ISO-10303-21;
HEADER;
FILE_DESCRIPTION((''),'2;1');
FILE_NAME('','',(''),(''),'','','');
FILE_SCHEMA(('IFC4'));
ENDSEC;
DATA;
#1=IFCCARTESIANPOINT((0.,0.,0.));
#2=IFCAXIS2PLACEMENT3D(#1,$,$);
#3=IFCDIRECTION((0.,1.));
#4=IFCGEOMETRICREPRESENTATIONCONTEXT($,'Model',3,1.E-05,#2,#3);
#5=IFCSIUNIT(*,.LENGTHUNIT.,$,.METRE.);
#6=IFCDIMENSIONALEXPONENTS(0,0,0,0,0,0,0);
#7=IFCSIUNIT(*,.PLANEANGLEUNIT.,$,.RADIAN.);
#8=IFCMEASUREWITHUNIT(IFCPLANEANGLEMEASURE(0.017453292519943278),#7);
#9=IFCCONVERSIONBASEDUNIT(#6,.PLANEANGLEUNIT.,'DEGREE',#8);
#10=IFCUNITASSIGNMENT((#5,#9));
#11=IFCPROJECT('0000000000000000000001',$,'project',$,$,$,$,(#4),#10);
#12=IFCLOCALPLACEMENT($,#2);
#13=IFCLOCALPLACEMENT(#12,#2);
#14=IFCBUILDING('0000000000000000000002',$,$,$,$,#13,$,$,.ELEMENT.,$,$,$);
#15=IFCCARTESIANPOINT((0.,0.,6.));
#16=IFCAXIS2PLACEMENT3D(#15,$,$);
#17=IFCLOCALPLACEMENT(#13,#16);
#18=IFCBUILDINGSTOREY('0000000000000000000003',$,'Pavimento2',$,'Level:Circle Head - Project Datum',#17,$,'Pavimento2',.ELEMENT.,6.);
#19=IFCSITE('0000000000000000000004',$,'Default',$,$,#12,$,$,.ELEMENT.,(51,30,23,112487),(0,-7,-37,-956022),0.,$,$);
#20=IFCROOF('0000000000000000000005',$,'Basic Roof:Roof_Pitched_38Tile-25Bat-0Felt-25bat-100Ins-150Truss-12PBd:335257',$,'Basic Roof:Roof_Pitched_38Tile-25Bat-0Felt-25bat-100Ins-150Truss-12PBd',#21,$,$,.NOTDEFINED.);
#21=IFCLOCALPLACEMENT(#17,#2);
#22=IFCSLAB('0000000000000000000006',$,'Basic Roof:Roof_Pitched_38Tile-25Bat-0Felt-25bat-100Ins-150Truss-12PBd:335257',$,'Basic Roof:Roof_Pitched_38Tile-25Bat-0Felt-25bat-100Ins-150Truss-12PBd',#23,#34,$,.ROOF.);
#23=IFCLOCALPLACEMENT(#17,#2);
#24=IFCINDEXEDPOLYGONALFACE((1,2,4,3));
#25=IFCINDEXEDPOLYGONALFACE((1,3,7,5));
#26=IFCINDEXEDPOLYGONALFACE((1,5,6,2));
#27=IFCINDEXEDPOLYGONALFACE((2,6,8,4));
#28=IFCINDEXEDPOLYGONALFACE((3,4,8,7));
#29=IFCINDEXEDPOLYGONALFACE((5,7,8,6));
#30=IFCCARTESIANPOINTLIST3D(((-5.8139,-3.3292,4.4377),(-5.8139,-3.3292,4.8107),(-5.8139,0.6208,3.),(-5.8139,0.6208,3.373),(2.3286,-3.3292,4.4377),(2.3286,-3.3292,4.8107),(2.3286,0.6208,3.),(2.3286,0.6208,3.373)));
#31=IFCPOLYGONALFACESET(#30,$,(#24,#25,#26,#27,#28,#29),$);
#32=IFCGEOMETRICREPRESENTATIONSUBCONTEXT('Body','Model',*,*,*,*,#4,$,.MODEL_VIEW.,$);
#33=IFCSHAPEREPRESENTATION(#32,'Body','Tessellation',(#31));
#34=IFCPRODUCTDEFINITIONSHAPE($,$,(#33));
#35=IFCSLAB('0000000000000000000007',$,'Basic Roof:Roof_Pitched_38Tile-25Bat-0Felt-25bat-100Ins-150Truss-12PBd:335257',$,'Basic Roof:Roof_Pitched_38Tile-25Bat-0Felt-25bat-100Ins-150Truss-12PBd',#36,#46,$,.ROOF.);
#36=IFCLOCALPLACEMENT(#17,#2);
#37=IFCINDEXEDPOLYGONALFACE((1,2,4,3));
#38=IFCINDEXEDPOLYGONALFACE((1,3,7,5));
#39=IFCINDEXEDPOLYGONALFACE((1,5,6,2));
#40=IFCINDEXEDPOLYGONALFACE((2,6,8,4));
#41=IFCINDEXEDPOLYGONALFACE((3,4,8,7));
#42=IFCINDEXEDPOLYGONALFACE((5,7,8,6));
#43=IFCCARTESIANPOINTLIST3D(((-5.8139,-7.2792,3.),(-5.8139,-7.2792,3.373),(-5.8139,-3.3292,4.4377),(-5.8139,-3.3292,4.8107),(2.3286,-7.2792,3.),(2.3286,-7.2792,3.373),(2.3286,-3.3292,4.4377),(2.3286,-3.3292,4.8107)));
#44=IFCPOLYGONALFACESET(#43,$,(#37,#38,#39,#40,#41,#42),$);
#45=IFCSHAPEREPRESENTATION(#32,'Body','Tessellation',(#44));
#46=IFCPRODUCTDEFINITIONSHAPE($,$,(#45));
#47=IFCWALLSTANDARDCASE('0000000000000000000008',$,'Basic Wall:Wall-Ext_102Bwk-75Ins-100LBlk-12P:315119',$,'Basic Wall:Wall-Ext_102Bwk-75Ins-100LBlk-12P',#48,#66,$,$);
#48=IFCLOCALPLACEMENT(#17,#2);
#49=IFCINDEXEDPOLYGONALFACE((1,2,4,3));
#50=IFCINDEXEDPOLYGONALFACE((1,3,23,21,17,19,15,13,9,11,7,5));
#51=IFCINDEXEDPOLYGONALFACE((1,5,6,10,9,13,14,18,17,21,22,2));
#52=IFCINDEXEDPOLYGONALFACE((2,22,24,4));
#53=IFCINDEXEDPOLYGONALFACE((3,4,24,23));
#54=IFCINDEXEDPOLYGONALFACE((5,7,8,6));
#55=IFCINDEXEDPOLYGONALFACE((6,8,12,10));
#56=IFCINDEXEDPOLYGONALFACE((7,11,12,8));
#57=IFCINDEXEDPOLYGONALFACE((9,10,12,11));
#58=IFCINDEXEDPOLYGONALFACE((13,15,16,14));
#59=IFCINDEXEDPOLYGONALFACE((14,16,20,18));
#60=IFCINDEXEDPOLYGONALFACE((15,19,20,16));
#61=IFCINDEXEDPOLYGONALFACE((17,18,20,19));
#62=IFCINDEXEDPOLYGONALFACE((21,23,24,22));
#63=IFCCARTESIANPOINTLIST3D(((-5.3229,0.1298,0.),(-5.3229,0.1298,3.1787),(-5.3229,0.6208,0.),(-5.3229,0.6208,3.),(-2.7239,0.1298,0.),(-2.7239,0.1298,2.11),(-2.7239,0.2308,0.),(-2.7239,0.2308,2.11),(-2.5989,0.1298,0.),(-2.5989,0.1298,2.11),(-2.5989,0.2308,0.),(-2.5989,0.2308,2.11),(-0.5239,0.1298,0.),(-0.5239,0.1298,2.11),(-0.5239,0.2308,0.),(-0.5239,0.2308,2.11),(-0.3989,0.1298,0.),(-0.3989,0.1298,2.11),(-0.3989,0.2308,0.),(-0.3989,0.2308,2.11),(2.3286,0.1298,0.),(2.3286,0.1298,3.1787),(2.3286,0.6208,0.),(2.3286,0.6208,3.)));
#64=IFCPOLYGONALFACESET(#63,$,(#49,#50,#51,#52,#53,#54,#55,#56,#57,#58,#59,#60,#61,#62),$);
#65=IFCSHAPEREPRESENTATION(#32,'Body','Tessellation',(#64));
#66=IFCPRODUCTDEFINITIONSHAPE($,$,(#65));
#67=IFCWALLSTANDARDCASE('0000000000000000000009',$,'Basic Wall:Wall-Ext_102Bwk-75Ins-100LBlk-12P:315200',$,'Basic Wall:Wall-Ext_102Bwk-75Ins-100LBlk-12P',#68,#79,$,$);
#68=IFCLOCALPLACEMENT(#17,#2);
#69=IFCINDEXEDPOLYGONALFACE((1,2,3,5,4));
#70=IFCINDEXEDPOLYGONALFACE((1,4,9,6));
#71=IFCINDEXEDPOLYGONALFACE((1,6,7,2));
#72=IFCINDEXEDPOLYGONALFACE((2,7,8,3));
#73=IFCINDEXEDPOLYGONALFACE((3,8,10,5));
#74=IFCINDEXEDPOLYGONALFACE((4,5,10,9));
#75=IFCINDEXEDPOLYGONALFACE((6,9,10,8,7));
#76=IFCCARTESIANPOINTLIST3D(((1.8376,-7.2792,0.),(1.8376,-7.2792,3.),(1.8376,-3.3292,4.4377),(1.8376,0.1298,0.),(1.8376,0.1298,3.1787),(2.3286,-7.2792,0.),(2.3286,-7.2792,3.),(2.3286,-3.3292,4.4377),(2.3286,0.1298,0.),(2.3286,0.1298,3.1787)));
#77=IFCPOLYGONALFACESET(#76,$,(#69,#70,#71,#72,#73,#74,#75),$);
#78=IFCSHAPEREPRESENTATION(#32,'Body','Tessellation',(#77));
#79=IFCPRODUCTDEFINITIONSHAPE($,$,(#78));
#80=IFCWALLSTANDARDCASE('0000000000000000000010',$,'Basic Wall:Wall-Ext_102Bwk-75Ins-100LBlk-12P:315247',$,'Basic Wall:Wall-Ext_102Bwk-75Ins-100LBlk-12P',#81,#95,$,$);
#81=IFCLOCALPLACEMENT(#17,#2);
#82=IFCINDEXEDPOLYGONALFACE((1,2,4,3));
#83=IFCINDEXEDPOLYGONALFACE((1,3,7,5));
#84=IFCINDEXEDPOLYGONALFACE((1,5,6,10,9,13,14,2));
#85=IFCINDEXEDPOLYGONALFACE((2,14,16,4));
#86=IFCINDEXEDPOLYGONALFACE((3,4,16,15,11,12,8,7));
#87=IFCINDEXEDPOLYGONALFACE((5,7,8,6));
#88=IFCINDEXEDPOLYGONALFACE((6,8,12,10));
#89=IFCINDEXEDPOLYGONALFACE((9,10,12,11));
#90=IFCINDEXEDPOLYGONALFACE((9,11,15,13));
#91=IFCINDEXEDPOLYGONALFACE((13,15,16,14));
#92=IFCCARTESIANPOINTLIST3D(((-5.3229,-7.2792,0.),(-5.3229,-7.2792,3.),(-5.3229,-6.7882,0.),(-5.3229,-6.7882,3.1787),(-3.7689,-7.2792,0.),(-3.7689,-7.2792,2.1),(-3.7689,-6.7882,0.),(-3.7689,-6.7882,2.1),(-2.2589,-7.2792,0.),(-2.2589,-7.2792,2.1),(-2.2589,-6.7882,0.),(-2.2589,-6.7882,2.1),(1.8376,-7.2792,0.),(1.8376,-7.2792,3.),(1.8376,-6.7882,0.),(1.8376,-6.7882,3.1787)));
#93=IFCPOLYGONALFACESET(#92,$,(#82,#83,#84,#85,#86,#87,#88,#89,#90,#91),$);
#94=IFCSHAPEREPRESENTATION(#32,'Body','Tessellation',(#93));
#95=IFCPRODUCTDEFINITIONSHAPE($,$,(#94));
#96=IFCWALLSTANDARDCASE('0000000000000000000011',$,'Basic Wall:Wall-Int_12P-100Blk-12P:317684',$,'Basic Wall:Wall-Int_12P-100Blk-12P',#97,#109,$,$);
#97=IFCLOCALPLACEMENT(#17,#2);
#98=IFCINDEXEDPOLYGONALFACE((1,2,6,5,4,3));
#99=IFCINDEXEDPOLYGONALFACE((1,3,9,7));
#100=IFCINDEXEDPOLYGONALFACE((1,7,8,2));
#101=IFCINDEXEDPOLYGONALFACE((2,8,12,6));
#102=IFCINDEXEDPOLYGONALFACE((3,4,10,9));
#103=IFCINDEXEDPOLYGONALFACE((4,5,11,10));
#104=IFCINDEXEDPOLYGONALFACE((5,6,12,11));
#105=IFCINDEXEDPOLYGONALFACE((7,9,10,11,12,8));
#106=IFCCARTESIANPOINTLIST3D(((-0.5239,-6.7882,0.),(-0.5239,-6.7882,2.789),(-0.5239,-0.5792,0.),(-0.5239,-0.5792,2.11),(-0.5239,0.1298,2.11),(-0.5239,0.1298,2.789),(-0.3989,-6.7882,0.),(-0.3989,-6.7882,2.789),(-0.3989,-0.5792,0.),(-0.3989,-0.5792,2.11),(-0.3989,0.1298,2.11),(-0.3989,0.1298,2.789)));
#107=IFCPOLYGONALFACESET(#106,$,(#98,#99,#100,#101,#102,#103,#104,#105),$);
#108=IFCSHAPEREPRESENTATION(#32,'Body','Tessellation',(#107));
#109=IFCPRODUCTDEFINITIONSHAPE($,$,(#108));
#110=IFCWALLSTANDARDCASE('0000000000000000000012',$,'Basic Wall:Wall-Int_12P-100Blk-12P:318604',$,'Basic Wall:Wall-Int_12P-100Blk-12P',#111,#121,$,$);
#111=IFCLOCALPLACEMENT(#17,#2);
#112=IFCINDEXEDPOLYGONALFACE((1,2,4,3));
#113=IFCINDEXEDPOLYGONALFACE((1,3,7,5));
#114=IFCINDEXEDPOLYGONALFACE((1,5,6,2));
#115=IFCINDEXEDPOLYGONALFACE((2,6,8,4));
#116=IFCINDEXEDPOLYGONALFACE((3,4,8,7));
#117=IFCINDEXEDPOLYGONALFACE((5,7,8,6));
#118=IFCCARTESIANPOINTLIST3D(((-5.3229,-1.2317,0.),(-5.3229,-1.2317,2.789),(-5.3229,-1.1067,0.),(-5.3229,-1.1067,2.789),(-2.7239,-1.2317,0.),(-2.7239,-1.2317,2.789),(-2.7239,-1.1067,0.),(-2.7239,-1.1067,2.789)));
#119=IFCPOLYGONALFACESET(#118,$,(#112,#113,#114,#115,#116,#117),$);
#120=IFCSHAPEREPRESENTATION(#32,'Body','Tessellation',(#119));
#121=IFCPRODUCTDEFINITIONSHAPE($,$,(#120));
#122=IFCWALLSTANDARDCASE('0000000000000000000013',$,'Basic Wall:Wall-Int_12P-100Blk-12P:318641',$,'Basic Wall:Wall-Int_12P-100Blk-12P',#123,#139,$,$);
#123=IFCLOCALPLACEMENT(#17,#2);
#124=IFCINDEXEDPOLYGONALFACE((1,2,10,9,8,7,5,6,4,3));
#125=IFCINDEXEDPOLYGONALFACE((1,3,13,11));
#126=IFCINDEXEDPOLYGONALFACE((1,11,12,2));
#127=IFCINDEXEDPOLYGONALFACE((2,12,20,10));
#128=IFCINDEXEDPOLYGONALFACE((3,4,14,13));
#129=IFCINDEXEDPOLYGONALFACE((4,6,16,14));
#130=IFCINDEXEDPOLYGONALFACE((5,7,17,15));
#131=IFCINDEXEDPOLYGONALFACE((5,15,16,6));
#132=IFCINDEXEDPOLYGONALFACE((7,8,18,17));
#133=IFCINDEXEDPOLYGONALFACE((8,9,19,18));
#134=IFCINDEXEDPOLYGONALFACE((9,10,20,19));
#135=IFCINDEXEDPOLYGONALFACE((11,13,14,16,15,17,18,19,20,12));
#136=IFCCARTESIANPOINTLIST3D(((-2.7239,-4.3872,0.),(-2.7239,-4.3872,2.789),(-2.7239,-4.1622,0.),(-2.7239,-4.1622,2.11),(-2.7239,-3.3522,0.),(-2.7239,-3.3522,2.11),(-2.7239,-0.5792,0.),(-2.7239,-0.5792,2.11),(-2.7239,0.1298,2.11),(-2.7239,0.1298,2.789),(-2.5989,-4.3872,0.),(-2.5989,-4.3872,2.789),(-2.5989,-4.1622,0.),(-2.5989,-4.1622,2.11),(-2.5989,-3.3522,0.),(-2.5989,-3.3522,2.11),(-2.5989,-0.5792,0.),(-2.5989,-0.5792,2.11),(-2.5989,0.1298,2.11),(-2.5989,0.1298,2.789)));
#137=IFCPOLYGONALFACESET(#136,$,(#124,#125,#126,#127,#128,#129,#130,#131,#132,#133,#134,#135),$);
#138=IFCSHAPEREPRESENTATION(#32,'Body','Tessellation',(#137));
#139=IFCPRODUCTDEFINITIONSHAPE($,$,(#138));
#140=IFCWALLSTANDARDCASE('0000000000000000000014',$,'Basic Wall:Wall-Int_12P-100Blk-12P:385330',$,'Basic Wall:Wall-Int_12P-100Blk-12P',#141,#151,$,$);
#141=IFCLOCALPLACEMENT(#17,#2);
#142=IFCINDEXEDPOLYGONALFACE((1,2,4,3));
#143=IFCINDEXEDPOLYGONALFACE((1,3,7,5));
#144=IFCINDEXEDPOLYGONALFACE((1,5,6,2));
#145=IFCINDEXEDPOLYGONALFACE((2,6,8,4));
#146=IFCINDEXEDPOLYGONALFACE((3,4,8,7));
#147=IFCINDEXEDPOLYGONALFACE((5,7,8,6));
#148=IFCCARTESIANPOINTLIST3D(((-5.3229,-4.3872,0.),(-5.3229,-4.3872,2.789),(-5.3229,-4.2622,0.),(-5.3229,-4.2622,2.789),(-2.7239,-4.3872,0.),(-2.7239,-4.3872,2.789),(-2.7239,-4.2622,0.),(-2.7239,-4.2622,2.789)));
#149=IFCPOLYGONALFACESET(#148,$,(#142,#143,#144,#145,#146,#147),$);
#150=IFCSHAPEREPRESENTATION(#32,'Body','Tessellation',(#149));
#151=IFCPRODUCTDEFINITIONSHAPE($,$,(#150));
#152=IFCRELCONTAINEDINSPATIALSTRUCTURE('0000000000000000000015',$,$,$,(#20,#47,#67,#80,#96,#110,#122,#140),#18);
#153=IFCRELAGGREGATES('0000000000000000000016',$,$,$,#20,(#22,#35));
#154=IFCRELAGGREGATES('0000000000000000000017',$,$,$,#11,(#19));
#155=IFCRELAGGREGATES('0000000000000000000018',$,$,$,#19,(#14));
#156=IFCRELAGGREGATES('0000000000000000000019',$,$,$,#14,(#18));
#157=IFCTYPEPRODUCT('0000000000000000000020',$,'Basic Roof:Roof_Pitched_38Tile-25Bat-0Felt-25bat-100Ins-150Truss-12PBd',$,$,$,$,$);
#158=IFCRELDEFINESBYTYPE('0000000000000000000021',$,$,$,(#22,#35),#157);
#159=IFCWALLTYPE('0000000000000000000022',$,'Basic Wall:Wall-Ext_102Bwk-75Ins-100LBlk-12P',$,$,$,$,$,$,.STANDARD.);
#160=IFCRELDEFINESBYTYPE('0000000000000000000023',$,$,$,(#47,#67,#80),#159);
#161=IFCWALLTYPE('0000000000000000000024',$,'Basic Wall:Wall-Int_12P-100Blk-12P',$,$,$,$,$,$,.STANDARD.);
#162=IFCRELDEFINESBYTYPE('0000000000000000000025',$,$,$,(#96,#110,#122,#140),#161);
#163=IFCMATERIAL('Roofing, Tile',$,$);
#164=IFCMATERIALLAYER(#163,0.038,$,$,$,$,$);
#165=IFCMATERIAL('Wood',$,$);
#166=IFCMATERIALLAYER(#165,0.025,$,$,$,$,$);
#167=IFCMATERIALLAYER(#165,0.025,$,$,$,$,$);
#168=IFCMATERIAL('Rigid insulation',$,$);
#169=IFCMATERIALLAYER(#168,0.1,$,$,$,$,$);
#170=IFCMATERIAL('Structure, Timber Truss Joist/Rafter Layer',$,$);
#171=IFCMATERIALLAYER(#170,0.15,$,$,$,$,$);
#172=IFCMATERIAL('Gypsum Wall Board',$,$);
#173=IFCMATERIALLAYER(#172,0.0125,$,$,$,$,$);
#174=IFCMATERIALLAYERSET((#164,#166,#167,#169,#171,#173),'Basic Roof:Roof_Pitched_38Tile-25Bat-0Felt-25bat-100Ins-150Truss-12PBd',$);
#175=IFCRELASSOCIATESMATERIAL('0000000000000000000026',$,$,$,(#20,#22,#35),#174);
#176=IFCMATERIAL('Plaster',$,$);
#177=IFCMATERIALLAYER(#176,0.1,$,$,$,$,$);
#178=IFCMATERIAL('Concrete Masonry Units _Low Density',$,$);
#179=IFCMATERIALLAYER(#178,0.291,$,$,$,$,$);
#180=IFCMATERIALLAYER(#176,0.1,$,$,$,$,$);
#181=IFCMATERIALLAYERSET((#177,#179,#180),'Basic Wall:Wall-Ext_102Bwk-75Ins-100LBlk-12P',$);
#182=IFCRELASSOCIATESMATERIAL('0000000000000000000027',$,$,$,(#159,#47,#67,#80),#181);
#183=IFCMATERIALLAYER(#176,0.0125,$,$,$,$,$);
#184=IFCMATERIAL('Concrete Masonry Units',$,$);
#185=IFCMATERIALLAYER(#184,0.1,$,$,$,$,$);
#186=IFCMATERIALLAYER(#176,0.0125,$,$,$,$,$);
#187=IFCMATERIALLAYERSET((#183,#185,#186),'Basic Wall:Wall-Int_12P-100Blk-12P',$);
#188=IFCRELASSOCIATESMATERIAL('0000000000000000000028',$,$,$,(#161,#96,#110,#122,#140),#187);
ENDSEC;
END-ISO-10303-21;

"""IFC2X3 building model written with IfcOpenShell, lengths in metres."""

from ifc_helpers import new_model, entity, si_unit, converted_unit, direction, frame, frame_2d, origin, origin_with_axes, place, context, subcontext, project, spatial, polyline, rectangle, extrude, clip, bounded_halfspace, material, layer, layer_set, layer_usage, type_object, element, aggregate, save


model = new_model("IFC2X3")

# Units and contexts
model_context = context("Model", 3, precision=1e-05, world=origin(), true_north=direction((0.0, 1.0)))
body_context = subcontext(model_context, "Body", "Model", "MODEL_VIEW")
ifc_project = project(units=[si_unit("LENGTHUNIT", "METRE"), converted_unit("PLANEANGLEUNIT", "DEGREE", entity("IfcPlaneAngleMeasure", 0.017453292519943278), si_unit("PLANEANGLEUNIT", "RADIAN"), dimensions=[0, 0, 0, 0, 0, 0, 0])], contexts=[model_context])

# Site, building, storey
site_placement = place(None, origin())
site = spatial("IfcSite", under=ifc_project, at=site_placement, Name="Default", CompositionType="ELEMENT", RefLatitude=(51, 30, 23, 112487), RefLongitude=(0, -7, -37, -956022), RefElevation=0.0)
building_placement = place(site_placement, origin())
building = spatial("IfcBuilding", under=site, at=building_placement, CompositionType="ELEMENT")
storey_placement = place(building_placement, frame((0.0, 0.0, 6.0)))
storey = spatial("IfcBuildingStorey", under=building, at=storey_placement, Name="Pavimento2", ObjectType="Level:Circle Head - Project Datum", LongName="Pavimento2", CompositionType="ELEMENT", Elevation=6.0)

# Roof, slabs
ifc_material_1 = material(Name="Roofing, Tile")
ifc_layer_1 = layer(ifc_material_1, 0.038)
ifc_material_2 = material(Name="Wood")
ifc_layer_2 = layer(ifc_material_2, 0.025)
ifc_layer_3 = layer(ifc_material_2, 0.025)
ifc_material_3 = material(Name="Rigid insulation")
ifc_layer_4 = layer(ifc_material_3, 0.1)
ifc_material_4 = material(Name="Structure, Timber Truss Joist/Rafter Layer")
ifc_layer_5 = layer(ifc_material_4, 0.15)
ifc_material_5 = material(Name="Gypsum Wall Board")
ifc_layer_6 = layer(ifc_material_5, 0.0125)
ifc_layer_set_1 = layer_set([ifc_layer_1, ifc_layer_2, ifc_layer_3, ifc_layer_4, ifc_layer_5, ifc_layer_6], Name="Basic Roof:Roof_Pitched_38Tile-25Bat-0Felt-25bat-100Ins-150Truss-12PBd")
roof_placement = place(storey_placement, frame((-5.8139, -7.2792, 3.0), z_axis=(0.0, 0.0, 1.0), x_axis=(1.0, 0.0, 0.0)))
roof = element("IfcRoof", 1, at=roof_placement, inside=storey, material=ifc_layer_set_1, Name="Basic Roof:Roof_Pitched_38Tile-25Bat-0Felt-25bat-100Ins-150Truss-12PBd:335257", ObjectType="Basic Roof:Roof_Pitched_38Tile-25Bat-0Felt-25bat-100Ins-150Truss-12PBd", ShapeType="NOTDEFINED")
type_product = type_object("IfcTypeProduct", Name="Basic Roof:Roof_Pitched_38Tile-25Bat-0Felt-25bat-100Ins-150Truss-12PBd")
slab_1_placement = place(roof_placement, origin_with_axes())
slab_1 = element("IfcSlab", 2, at=slab_1_placement, type_object=type_product, material=ifc_layer_set_1, Name="Basic Roof:Roof_Pitched_38Tile-25Bat-0Felt-25bat-100Ins-150Truss-12PBd:335257", ObjectType="Basic Roof:Roof_Pitched_38Tile-25Bat-0Felt-25bat-100Ins-150Truss-12PBd", PredefinedType="ROOF", context=body_context, shape_type="SweptSolid", body=[
    extrude(rectangle(XDim=8.1425, YDim=4.2035, at=frame_2d((0.0, 0.0), x_axis=(1.0, 0.0))), frame((4.0713, 5.925, 0.7188), z_axis=(0.0, 0.34202, 0.939693), x_axis=(1.0, 0.0, 0.0)), (0.0, -0.34202, 0.939693), 0.373),
])
slab_2_placement = place(roof_placement, origin_with_axes())
slab_2 = element("IfcSlab", 3, at=slab_2_placement, type_object=type_product, material=ifc_layer_set_1, Name="Basic Roof:Roof_Pitched_38Tile-25Bat-0Felt-25bat-100Ins-150Truss-12PBd:335257", ObjectType="Basic Roof:Roof_Pitched_38Tile-25Bat-0Felt-25bat-100Ins-150Truss-12PBd", PredefinedType="ROOF", context=body_context, shape_type="SweptSolid", body=[
    extrude(rectangle(XDim=4.2035, YDim=8.1425, at=frame_2d((0.0, 0.0), x_axis=(0.0, 1.0))), frame((4.0713, 1.975, 0.7188), z_axis=(0.0, -0.34202, 0.939693), x_axis=(1.0, 0.0, 0.0)), (0.0, 0.34202, 0.939693), 0.373),
])
aggregate(roof, [slab_1, slab_2])

# Wall, openings
ifc_material_6 = material(Name="Plaster")
ifc_layer_7 = layer(ifc_material_6, 0.1)
ifc_material_7 = material(Name="Concrete Masonry Units _Low Density")
ifc_layer_8 = layer(ifc_material_7, 0.291)
ifc_layer_9 = layer(ifc_material_6, 0.1)
ifc_layer_set_2 = layer_set([ifc_layer_7, ifc_layer_8, ifc_layer_9], Name="Basic Wall:Wall-Ext_102Bwk-75Ins-100LBlk-12P")
ifc_layer_usage_1 = layer_usage(ifc_layer_set_2, "AXIS2", "NEGATIVE", 0.2455)
wall_type_1 = type_object("IfcWallType", Name="Basic Wall:Wall-Ext_102Bwk-75Ins-100LBlk-12P", PredefinedType="STANDARD", material=ifc_layer_set_2)
wall_1_placement = place(storey_placement, frame((-5.3229, 0.3753, 0.0)))
wall_1 = element("IfcWallStandardCase", 4, at=wall_1_placement, inside=storey, type_object=wall_type_1, material=ifc_layer_usage_1, Name="Basic Wall:Wall-Ext_102Bwk-75Ins-100LBlk-12P:315119", ObjectType="Basic Wall:Wall-Ext_102Bwk-75Ins-100LBlk-12P", context=body_context, shape_type="Clipping", body=[
    clip(extrude(rectangle(XDim=7.6515, YDim=0.491, at=frame_2d((3.8258, 0.0), x_axis=(-1.0, 0.0))), origin(), (0.0, 0.0, 1.0), 3.1787), bounded_halfspace(frame((0.0, -0.2455, 3.1787), z_axis=(0.0, 0.34202, 0.939693), x_axis=(-1.0, 0.0, 0.0)), False, frame((0.0, -0.2455, 3.1787)), polyline([(0.0, 0.0), (7.1605, 0.0), (7.6515, 0.0), (7.6515, 0.491), (0.0, 0.491), (0.0, 0.0)]))),
])
opening_1_placement = place(wall_1_placement, origin())
element("IfcOpeningElement", 5, at=opening_1_placement, cuts=wall_1, ObjectType="Opening", context=body_context, shape_type="SweptSolid", body=[
    extrude(rectangle(XDim=2.11, YDim=0.125, at=frame_2d((0.0, 0.0), x_axis=(0.0, 1.0))), frame((2.6615, -0.9545, 1.055), z_axis=(0.0, 1.0, 0.0), x_axis=(-1.0, 0.0, 0.0)), (0.0, 0.0, 1.0), 0.81),
])
opening_2_placement = place(wall_1_placement, origin())
element("IfcOpeningElement", 6, at=opening_2_placement, cuts=wall_1, ObjectType="Opening", context=body_context, shape_type="SweptSolid", body=[
    extrude(rectangle(XDim=2.11, YDim=0.125, at=frame_2d((0.0, 0.0), x_axis=(0.0, 1.0))), frame((4.8615, -0.9545, 1.055), z_axis=(0.0, 1.0, 0.0), x_axis=(-1.0, 0.0, 0.0)), (0.0, 0.0, 1.0), 0.81),
])

# Wall
wall_2_placement = place(storey_placement, frame((2.0831, 0.1298, 0.0), z_axis=(0.0, 0.0, 1.0), x_axis=(0.0, -1.0, 0.0)))
element("IfcWallStandardCase", 7, at=wall_2_placement, inside=storey, type_object=wall_type_1, material=ifc_layer_usage_1, Name="Basic Wall:Wall-Ext_102Bwk-75Ins-100LBlk-12P:315200", ObjectType="Basic Wall:Wall-Ext_102Bwk-75Ins-100LBlk-12P", context=body_context, shape_type="Clipping", body=[
    clip(clip(extrude(rectangle(XDim=7.409, YDim=0.491, at=frame_2d((3.7045, 0.0), x_axis=(-1.0, 0.0))), origin(), (0.0, 0.0, 1.0), 4.4377), bounded_halfspace(frame((0.0, -0.2455, 3.1787), z_axis=(-0.34202, 0.0, 0.939693), x_axis=(0.0, -1.0, 0.0)), False, frame((0.0, -0.2455, 3.1787)), polyline([(0.0, 0.0), (3.459, 0.0), (3.459, 0.491), (0.0, 0.491), (0.0, 0.0)]))), bounded_halfspace(frame((3.459, -0.2455, 4.4377), z_axis=(0.34202, 0.0, 0.939693), x_axis=(0.0, 1.0, 0.0)), False, frame((3.459, -0.2455, 4.4377)), polyline([(0.0, 0.0), (3.459, 0.0), (3.95, 0.0), (3.95, 0.491), (0.0, 0.491), (0.0, 0.0)]))),
])

# Walls, openings
wall_3_placement = place(storey_placement, frame((1.8376, -7.0337, 0.0), z_axis=(0.0, 0.0, 1.0), x_axis=(-1.0, 0.0, 0.0)))
wall_3 = element("IfcWallStandardCase", 8, at=wall_3_placement, inside=storey, type_object=wall_type_1, material=ifc_layer_usage_1, Name="Basic Wall:Wall-Ext_102Bwk-75Ins-100LBlk-12P:315247", ObjectType="Basic Wall:Wall-Ext_102Bwk-75Ins-100LBlk-12P", context=body_context, shape_type="Clipping", body=[
    clip(extrude(rectangle(XDim=7.1605, YDim=0.491, at=frame_2d((3.5803, 0.0), x_axis=(1.0, 0.0))), origin(), (0.0, 0.0, 1.0), 3.1787), bounded_halfspace(frame((0.0, -0.2455, 3.1787), z_axis=(0.0, 0.34202, 0.939693), x_axis=(-1.0, 0.0, 0.0)), False, frame((0.0, -0.2455, 3.1787)), polyline([(0.0, 0.0), (7.1605, 0.0), (7.1605, 0.491), (0.0, 0.491), (0.0, 0.0)]))),
])
opening_3_placement = place(wall_3_placement, frame((1.8376, -7.0337, 0.0), z_axis=(0.0, 0.0, 1.0), x_axis=(-1.0, 0.0, 0.0)))
element("IfcOpeningElement", 9, at=opening_3_placement, cuts=wall_3, ObjectType="Opening", context=body_context, shape_type="SweptSolid", body=[
    extrude(rectangle(XDim=2.1, YDim=1.51, at=frame_2d((0.0, 0.0), x_axis=(0.0, 1.0))), frame((-3.0139, -6.4882, 1.05), z_axis=(0.0, -1.0, 0.0), x_axis=(-1.0, 0.0, 0.0)), (0.0, 0.0, 1.0), 1.091),
])
ifc_layer_10 = layer(ifc_material_6, 0.0125)
ifc_material_8 = material(Name="Concrete Masonry Units")
ifc_layer_11 = layer(ifc_material_8, 0.1)
ifc_layer_12 = layer(ifc_material_6, 0.0125)
ifc_layer_set_3 = layer_set([ifc_layer_10, ifc_layer_11, ifc_layer_12], Name="Basic Wall:Wall-Int_12P-100Blk-12P")
ifc_layer_usage_2 = layer_usage(ifc_layer_set_3, "AXIS2", "NEGATIVE", 0.0625)
wall_type_2 = type_object("IfcWallType", Name="Basic Wall:Wall-Int_12P-100Blk-12P", PredefinedType="STANDARD", material=ifc_layer_set_3)
wall_4_placement = place(storey_placement, frame((-0.4614, 0.1298, 0.0), z_axis=(0.0, 0.0, 1.0), x_axis=(0.0, -1.0, 0.0)))
wall_4 = element("IfcWallStandardCase", 10, at=wall_4_placement, inside=storey, type_object=wall_type_2, material=ifc_layer_usage_2, Name="Basic Wall:Wall-Int_12P-100Blk-12P:317684", ObjectType="Basic Wall:Wall-Int_12P-100Blk-12P", context=body_context, shape_type="SweptSolid", body=[
    extrude(rectangle(XDim=6.918, YDim=0.125, at=frame_2d((3.459, 0.0), x_axis=(-1.0, 0.0))), origin(), (0.0, 0.0, 1.0), 2.789),
])
opening_4_placement = place(wall_4_placement, frame((0.709, 0.0625, 0.0)))
element("IfcOpeningElement", 11, at=opening_4_placement, cuts=wall_4, ObjectType="Opening", context=body_context, shape_type="SweptSolid", body=[
    extrude(rectangle(XDim=2.11, YDim=0.81, at=frame_2d((1.055, 0.405), x_axis=(1.0, 0.0))), frame((0.0, 0.0, 0.0), z_axis=(0.0, -1.0, 0.0), x_axis=(0.0, 0.0, 1.0)), (0.0, 0.0, 1.0), 0.125),
])

# Wall
wall_5_placement = place(storey_placement, frame((-2.7239, -1.1692, 0.0), z_axis=(0.0, 0.0, 1.0), x_axis=(-1.0, 0.0, 0.0)))
element("IfcWallStandardCase", 12, at=wall_5_placement, inside=storey, type_object=wall_type_2, material=ifc_layer_usage_2, Name="Basic Wall:Wall-Int_12P-100Blk-12P:318604", ObjectType="Basic Wall:Wall-Int_12P-100Blk-12P", context=body_context, shape_type="SweptSolid", body=[
    extrude(rectangle(XDim=2.599, YDim=0.125, at=frame_2d((1.2995, 0.0), x_axis=(-1.0, 0.0))), origin(), (0.0, 0.0, 1.0), 2.789),
])

# Wall, openings
wall_6_placement = place(storey_placement, frame((-2.6614, 0.1298, 0.0), z_axis=(0.0, 0.0, 1.0), x_axis=(0.0, -1.0, 0.0)))
wall_6 = element("IfcWallStandardCase", 13, at=wall_6_placement, inside=storey, type_object=wall_type_2, material=ifc_layer_usage_2, Name="Basic Wall:Wall-Int_12P-100Blk-12P:318641", ObjectType="Basic Wall:Wall-Int_12P-100Blk-12P", context=body_context, shape_type="SweptSolid", body=[
    extrude(rectangle(XDim=4.517, YDim=0.125, at=frame_2d((2.2585, 0.0), x_axis=(-1.0, 0.0))), origin(), (0.0, 0.0, 1.0), 2.789),
])
opening_5_placement = place(wall_6_placement, frame((0.709, 0.0625, 0.0)))
element("IfcOpeningElement", 14, at=opening_5_placement, cuts=wall_6, ObjectType="Opening", context=body_context, shape_type="SweptSolid", body=[
    extrude(rectangle(XDim=2.11, YDim=0.81, at=frame_2d((1.055, 0.405), x_axis=(1.0, 0.0))), frame((0.0, 0.0, 0.0), z_axis=(0.0, -1.0, 0.0), x_axis=(0.0, 0.0, 1.0)), (0.0, 0.0, 1.0), 0.125),
])
opening_6_placement = place(wall_6_placement, frame((4.292, 0.0625, 0.0)))
element("IfcOpeningElement", 15, at=opening_6_placement, cuts=wall_6, ObjectType="Opening", context=body_context, shape_type="SweptSolid", body=[
    extrude(rectangle(XDim=2.11, YDim=0.81, at=frame_2d((1.055, 0.405), x_axis=(1.0, 0.0))), frame((0.0, 0.0, 0.0), z_axis=(0.0, -1.0, 0.0), x_axis=(0.0, 0.0, 1.0)), (0.0, 0.0, 1.0), 0.125),
])

# Wall
wall_7_placement = place(storey_placement, frame((-2.7239, -4.3247, 0.0), z_axis=(0.0, 0.0, 1.0), x_axis=(-1.0, 0.0, 0.0)))
element("IfcWallStandardCase", 16, at=wall_7_placement, inside=storey, type_object=wall_type_2, material=ifc_layer_usage_2, Name="Basic Wall:Wall-Int_12P-100Blk-12P:385330", ObjectType="Basic Wall:Wall-Int_12P-100Blk-12P", context=body_context, shape_type="SweptSolid", body=[
    extrude(rectangle(XDim=2.599, YDim=0.125, at=frame_2d((1.2995, 0.0), x_axis=(-1.0, 0.0))), origin(), (0.0, 0.0, 1.0), 2.789),
])

save(model, "model.ifc")
